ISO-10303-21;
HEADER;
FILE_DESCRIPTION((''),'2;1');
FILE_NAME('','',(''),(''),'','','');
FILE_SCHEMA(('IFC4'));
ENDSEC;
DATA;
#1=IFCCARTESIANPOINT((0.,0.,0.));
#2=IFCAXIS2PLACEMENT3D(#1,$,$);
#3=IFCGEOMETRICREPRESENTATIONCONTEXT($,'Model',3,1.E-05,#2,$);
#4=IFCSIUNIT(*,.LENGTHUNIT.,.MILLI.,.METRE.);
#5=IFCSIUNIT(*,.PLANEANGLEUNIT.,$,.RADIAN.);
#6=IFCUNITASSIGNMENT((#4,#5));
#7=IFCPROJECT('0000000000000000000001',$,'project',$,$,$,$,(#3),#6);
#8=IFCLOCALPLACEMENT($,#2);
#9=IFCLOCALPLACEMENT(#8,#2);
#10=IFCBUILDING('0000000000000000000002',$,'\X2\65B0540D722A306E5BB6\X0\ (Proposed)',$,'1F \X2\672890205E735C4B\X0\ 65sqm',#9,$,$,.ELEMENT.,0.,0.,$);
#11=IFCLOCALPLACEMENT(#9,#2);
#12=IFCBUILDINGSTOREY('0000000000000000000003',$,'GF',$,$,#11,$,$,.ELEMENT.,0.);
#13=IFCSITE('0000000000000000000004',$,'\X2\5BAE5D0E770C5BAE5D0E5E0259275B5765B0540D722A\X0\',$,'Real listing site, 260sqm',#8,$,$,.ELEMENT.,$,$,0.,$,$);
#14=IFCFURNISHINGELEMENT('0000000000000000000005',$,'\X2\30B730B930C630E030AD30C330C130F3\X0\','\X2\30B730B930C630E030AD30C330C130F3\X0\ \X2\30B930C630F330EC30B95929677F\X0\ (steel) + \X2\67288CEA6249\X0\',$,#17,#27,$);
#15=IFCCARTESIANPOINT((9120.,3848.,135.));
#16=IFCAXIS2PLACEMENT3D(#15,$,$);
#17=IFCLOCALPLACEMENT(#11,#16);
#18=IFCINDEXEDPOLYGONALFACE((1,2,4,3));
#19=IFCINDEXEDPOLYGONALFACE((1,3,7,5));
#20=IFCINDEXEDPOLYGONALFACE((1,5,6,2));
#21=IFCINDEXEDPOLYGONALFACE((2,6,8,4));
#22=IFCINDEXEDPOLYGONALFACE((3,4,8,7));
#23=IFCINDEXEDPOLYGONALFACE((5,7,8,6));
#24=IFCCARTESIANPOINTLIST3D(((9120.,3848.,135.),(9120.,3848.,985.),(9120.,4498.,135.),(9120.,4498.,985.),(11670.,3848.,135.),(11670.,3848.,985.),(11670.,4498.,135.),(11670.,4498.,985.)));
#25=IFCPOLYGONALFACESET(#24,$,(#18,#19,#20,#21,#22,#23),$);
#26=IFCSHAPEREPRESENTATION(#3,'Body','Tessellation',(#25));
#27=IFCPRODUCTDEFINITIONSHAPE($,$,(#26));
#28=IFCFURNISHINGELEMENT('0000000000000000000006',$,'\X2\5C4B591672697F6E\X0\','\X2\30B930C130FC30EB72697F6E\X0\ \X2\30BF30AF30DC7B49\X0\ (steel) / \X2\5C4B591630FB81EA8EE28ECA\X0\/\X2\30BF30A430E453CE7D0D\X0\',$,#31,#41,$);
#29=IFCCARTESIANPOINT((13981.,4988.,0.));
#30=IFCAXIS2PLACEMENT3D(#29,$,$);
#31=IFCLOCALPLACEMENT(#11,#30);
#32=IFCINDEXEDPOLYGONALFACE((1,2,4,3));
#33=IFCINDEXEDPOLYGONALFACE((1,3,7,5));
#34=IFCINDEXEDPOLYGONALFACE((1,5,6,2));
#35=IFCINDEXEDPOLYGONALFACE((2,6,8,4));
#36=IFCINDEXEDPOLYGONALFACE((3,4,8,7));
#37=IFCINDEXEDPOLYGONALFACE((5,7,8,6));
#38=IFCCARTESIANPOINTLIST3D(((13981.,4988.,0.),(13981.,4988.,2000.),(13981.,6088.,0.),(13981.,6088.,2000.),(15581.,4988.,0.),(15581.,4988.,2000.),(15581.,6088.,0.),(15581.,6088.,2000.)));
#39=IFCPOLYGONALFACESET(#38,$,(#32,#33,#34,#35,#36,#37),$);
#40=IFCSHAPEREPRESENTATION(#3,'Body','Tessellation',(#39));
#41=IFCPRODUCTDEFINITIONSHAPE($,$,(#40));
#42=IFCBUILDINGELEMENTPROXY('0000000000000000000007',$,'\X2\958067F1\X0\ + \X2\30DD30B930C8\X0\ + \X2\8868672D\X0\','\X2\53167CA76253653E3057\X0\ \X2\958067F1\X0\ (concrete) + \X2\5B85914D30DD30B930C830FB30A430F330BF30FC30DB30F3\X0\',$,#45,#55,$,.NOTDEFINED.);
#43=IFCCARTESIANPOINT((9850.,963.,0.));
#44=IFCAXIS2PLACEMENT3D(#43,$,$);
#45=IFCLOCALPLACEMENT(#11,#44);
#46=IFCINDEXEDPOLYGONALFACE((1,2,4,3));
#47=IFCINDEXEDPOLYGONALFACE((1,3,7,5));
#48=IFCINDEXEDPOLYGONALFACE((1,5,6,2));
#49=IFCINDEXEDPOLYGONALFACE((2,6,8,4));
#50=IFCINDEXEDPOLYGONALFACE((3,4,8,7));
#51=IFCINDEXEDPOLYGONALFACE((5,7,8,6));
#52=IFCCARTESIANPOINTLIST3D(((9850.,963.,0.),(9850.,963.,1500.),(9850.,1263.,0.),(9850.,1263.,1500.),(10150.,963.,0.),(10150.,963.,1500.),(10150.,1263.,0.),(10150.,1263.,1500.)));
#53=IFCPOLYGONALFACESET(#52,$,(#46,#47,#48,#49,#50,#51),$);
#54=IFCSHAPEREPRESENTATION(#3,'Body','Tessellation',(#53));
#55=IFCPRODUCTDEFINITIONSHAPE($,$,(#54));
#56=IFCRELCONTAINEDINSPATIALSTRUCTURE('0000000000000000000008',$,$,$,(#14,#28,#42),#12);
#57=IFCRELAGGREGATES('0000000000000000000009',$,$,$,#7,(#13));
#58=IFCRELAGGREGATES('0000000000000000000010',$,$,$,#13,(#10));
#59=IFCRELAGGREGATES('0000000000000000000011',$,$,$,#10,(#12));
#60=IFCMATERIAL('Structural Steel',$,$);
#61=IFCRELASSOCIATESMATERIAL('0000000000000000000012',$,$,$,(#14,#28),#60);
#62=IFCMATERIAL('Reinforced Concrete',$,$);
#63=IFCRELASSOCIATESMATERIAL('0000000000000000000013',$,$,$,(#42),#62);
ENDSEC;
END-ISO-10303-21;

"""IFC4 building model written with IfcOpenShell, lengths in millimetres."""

from ifc_helpers import new_model, si_unit, frame, frame_2d, origin, place, context, project, spatial, rectangle, extrude, material, element, save


model = new_model("IFC4")

# Units and contexts
model_context = context("Model", 3, precision=1e-05, world=origin())
ifc_project = project(units=[si_unit("LENGTHUNIT", "METRE", prefix="MILLI"), si_unit("PLANEANGLEUNIT", "RADIAN")], contexts=[model_context])

# Site, building, storey
site_placement = place(None, origin())
site = spatial("IfcSite", under=ifc_project, at=site_placement, Name="宮崎県宮崎市大字新名爪", ObjectType="Real listing site, 260sqm", CompositionType="ELEMENT", RefElevation=0.0)
building_placement = place(site_placement, origin())
building = spatial("IfcBuilding", under=site, at=building_placement, Name="新名爪の家 (Proposed)", ObjectType="1F 木造平屋 65sqm", CompositionType="ELEMENT", ElevationOfRefHeight=0.0, ElevationOfTerrain=0.0)
storey_placement = place(building_placement, origin())
storey = spatial("IfcBuildingStorey", under=building, at=storey_placement, Name="GF", CompositionType="ELEMENT", Elevation=0.0)

# Shared definitions
ifc_material_1 = material(Name="Structural Steel")

# Shared definitions
ifc_material_2 = material(Name="Reinforced Concrete")

# Furnishing elements
furnishing_1_placement = place(storey_placement, frame((9120.0, 3848.0, 135.0)))
element("IfcFurnishingElement", 1, at=furnishing_1_placement, inside=storey, material=ifc_material_1, Name="システムキッチン", Description="システムキッチン ステンレス天板 (steel) + 木質扉", context=model_context, shape_type="SweptSolid", body=[
    extrude(rectangle(XDim=2550.0, YDim=650.0, at=frame_2d((1275.0, 325.0))), frame((9120.0, 3848.0, 135.0)), (0.0, 0.0, 1.0), 850.0),
])
furnishing_2_placement = place(storey_placement, frame((13981.0, 4988.0, 0.0)))
element("IfcFurnishingElement", 2, at=furnishing_2_placement, inside=storey, material=ifc_material_1, Name="屋外物置", Description="スチール物置 タクボ等 (steel) / 屋外・自転車/タイヤ収納", context=model_context, shape_type="SweptSolid", body=[
    extrude(rectangle(XDim=1600.0, YDim=1100.0, at=frame_2d((800.0, 550.0))), frame((13981.0, 4988.0, 0.0)), (0.0, 0.0, 1.0), 2000.0),
])

# Building element proxy
proxy_placement = place(storey_placement, frame((9850.0, 963.0, 0.0)))
element("IfcBuildingElementProxy", 3, at=proxy_placement, inside=storey, material=ifc_material_2, Name="門柱 + ポスト + 表札", Description="化粧打放し 門柱 (concrete) + 宅配ポスト・インターホン", PredefinedType="NOTDEFINED", context=model_context, shape_type="SweptSolid", body=[
    extrude(rectangle(XDim=300.0, YDim=300.0, at=frame_2d((150.0, 150.0))), frame((9850.0, 963.0, 0.0)), (0.0, 0.0, 1.0), 1500.0),
])

save(model, "model.ifc")
